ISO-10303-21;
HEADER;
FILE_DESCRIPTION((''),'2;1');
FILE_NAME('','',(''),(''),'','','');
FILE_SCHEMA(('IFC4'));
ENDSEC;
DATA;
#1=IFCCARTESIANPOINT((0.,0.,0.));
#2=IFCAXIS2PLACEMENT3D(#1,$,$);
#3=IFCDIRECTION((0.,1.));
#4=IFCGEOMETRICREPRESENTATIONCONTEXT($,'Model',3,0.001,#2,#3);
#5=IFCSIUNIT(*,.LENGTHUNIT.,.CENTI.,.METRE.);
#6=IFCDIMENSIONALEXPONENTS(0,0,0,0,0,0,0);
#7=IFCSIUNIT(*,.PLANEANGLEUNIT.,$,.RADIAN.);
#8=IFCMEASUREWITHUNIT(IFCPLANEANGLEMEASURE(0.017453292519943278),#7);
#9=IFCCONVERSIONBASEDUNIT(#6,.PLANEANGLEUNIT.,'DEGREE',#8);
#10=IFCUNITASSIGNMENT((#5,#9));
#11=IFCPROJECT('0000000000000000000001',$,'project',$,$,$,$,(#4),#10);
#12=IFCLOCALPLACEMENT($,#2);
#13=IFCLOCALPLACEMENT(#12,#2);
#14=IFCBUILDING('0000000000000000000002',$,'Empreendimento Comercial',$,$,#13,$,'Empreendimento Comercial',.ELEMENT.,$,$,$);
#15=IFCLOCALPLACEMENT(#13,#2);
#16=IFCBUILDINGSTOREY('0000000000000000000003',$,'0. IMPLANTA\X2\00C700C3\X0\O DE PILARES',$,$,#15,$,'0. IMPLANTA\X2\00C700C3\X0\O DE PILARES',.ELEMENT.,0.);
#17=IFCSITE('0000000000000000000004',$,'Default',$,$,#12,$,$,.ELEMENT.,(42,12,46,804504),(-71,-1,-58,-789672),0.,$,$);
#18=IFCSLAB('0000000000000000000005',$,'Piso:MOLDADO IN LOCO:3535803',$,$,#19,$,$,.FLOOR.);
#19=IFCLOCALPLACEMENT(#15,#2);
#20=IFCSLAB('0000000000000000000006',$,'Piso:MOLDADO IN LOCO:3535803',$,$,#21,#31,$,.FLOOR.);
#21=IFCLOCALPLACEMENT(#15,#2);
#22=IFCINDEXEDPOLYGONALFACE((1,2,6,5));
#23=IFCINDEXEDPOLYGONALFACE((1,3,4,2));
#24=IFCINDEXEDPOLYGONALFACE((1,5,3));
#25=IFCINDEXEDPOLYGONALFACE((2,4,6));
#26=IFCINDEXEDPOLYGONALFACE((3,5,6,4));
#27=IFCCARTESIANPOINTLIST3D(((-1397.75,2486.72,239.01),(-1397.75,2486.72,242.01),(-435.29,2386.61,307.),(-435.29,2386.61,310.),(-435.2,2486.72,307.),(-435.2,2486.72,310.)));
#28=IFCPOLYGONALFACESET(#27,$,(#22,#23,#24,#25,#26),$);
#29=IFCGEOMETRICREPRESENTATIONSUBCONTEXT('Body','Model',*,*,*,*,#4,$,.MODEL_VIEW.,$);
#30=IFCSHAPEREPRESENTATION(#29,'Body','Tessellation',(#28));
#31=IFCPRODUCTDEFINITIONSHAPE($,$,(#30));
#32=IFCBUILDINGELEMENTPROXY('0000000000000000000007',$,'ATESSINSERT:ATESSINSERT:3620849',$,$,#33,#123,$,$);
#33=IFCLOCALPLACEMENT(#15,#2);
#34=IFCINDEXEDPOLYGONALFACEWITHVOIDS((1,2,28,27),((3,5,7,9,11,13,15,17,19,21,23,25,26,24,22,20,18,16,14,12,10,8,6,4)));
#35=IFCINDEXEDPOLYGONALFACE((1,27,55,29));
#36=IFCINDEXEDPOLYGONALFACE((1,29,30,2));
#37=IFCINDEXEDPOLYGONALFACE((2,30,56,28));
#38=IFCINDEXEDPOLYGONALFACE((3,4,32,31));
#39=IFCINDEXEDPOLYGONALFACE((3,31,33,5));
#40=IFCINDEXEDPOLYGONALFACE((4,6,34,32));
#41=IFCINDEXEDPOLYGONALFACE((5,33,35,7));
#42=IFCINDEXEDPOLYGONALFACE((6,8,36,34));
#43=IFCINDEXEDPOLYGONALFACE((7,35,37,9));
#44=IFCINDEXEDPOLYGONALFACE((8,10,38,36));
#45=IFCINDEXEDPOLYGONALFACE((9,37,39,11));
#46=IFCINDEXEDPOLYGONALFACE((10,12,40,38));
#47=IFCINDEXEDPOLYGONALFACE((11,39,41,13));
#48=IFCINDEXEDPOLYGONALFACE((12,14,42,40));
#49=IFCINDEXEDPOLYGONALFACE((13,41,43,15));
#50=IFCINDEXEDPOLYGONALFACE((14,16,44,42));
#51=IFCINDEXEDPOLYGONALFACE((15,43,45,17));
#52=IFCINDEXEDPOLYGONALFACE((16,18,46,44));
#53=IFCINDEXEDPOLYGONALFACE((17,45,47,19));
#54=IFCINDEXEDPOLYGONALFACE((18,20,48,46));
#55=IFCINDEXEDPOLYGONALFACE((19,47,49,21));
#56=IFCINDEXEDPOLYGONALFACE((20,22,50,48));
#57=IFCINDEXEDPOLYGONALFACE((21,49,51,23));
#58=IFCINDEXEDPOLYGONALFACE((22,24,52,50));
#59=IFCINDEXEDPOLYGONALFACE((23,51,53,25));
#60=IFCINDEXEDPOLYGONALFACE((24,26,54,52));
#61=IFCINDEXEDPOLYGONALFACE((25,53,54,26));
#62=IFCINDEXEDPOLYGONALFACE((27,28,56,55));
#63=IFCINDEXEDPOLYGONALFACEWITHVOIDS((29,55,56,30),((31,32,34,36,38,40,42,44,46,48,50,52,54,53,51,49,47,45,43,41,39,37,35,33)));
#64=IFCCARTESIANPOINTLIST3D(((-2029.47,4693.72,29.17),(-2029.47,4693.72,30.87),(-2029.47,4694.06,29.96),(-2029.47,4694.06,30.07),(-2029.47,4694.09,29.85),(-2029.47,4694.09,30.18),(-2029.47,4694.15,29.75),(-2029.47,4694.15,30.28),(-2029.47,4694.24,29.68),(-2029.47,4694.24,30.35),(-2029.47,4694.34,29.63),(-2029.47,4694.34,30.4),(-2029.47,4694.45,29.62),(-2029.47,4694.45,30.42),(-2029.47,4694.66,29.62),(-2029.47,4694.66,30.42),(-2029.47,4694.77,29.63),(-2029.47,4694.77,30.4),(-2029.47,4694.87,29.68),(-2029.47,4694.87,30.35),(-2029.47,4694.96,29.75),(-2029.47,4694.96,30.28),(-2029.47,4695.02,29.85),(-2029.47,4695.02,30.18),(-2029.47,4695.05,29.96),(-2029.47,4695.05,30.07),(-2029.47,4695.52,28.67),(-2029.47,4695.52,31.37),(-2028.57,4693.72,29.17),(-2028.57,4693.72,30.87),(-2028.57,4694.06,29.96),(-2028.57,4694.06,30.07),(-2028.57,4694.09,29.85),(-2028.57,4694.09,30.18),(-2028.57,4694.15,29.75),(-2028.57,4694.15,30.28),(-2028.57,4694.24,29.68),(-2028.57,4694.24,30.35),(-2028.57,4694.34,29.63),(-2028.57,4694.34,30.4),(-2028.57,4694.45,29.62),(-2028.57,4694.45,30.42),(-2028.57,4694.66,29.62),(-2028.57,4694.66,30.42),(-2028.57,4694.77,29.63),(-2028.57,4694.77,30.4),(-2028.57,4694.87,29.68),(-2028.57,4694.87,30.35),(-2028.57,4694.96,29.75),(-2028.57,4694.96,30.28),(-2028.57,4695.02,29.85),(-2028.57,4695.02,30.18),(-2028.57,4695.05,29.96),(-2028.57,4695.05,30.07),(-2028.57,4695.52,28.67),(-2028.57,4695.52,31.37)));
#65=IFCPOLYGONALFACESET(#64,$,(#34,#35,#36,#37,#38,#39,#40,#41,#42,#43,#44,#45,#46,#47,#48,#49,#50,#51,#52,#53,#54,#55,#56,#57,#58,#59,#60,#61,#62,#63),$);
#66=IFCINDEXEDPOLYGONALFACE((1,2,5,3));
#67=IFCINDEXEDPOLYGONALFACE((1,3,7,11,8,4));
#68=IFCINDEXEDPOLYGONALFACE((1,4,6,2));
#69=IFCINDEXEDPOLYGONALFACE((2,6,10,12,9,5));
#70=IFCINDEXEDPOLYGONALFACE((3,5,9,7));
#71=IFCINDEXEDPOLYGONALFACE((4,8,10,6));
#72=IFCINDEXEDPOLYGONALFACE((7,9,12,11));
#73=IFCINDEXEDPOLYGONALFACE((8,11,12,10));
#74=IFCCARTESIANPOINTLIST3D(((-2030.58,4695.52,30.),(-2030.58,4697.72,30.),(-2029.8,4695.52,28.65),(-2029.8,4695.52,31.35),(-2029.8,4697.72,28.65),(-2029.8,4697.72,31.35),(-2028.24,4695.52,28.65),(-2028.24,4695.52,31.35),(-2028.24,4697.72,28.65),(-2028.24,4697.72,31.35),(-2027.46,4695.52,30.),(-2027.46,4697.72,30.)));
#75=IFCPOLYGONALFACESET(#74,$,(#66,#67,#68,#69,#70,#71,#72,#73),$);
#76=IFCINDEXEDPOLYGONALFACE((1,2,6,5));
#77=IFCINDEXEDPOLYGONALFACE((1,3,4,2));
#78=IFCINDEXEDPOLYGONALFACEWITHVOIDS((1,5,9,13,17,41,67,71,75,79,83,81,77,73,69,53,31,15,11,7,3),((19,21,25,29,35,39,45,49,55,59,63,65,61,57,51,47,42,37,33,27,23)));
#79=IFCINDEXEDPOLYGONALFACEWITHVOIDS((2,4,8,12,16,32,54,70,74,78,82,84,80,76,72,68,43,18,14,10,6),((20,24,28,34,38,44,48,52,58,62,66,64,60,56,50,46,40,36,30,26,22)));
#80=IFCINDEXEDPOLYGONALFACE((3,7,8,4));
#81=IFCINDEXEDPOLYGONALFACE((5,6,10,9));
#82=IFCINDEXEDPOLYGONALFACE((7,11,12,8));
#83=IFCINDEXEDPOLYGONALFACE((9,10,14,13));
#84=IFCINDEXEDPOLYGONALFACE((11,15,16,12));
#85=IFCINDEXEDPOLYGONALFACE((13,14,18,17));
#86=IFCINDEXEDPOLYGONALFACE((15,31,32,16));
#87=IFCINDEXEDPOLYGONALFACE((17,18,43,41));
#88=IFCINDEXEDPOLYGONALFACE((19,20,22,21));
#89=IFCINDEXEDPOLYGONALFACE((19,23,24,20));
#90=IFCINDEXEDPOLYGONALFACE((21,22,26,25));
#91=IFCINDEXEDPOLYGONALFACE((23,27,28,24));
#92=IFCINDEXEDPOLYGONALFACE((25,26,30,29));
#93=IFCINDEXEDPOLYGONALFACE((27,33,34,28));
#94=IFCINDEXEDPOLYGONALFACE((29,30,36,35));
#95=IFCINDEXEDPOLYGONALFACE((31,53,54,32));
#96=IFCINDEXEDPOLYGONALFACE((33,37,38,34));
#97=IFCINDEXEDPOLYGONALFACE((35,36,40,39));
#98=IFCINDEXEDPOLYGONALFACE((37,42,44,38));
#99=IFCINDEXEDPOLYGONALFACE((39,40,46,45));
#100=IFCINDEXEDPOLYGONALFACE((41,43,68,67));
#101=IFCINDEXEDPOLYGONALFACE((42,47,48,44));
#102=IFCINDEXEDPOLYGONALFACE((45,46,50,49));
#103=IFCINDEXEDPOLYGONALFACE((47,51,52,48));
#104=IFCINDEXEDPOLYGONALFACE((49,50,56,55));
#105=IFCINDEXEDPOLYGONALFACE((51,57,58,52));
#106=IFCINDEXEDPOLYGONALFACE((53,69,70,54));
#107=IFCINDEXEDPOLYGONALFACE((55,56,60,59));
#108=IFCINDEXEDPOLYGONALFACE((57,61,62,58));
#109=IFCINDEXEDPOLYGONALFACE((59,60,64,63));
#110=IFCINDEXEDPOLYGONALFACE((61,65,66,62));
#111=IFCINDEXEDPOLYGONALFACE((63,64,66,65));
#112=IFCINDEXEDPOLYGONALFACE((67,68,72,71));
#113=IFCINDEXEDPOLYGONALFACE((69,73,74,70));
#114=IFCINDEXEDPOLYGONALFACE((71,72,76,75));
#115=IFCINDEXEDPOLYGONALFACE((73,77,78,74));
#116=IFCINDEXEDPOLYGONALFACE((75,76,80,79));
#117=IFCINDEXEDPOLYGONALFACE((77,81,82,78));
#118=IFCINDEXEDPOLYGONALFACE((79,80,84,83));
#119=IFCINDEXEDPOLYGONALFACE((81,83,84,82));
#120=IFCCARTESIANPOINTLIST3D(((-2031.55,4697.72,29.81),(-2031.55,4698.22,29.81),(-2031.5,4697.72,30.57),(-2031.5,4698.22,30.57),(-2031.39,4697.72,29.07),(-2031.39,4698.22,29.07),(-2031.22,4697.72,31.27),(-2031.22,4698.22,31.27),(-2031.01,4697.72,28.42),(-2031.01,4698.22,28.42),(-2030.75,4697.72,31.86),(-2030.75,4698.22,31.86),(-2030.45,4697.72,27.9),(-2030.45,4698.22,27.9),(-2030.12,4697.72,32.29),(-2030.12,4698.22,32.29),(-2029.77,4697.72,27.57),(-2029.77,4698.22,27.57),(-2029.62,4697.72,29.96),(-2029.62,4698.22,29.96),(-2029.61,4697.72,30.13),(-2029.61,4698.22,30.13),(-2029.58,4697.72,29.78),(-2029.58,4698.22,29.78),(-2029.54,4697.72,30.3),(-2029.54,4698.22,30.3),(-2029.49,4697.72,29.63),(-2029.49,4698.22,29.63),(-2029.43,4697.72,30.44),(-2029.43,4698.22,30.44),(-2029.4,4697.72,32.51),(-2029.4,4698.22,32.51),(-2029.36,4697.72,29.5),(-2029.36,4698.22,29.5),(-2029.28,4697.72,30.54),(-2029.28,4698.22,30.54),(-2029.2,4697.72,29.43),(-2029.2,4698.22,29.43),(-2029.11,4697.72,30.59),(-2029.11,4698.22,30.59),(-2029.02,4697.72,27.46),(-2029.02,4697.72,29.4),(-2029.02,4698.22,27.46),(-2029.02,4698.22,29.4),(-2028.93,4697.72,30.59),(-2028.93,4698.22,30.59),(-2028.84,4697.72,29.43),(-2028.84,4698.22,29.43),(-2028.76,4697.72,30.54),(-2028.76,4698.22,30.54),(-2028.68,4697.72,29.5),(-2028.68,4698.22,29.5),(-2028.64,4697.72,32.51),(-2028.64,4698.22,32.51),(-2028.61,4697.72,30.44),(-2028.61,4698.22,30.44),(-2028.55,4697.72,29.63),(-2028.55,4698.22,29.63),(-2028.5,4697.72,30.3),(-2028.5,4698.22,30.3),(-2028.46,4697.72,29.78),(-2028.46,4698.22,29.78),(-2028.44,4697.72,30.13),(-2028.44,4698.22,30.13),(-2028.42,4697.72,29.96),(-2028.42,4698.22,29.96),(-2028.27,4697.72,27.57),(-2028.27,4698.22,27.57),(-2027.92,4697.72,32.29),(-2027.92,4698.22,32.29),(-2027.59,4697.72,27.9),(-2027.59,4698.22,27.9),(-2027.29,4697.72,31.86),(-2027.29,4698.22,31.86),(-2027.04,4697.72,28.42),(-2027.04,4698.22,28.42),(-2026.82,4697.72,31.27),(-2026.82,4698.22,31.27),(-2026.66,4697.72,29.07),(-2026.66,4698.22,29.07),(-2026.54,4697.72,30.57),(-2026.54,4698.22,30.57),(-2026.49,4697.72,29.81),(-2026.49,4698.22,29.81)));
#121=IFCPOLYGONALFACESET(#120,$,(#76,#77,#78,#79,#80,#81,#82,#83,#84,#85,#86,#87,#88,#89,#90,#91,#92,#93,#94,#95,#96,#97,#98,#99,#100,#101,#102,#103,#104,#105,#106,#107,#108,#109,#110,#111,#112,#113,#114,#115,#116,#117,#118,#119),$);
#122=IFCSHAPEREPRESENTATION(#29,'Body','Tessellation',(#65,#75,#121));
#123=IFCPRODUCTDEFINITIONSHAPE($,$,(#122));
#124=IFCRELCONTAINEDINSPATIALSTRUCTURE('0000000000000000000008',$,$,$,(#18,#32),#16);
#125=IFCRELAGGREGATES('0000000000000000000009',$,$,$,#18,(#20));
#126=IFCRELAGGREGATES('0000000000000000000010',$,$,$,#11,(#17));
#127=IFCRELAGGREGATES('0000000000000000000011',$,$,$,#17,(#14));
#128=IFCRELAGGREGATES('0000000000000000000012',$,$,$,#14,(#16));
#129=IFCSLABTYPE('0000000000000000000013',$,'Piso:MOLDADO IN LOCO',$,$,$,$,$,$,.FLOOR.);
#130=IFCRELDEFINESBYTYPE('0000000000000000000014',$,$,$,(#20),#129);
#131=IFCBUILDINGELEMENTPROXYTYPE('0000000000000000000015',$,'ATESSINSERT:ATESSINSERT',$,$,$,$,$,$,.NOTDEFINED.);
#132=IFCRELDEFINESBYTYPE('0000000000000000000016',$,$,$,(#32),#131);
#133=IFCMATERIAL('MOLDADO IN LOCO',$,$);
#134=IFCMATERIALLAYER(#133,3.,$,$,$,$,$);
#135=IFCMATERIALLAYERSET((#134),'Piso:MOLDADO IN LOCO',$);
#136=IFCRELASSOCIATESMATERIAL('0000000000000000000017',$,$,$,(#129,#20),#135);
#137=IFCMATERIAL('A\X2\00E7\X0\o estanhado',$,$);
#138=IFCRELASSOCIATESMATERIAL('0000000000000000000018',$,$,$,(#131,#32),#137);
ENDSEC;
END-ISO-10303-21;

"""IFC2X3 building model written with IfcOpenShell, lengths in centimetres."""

from ifc_helpers import new_model, entity, si_unit, converted_unit, direction, frame, frame_2d, origin, place, context, subcontext, project, spatial, polyline, circle_curve, parameter, trimmed, segment, composite_curve, hollow_circle, outline, extrude, source, transform, mapped, material, layer, layer_set, type_object, type_shapes, element, aggregate, save


model = new_model("IFC2X3")

# Units and contexts
model_context = context("Model", 3, precision=0.001, world=origin(), true_north=direction((0.0, 1.0)))
body_context = subcontext(model_context, "Body", "Model", "MODEL_VIEW")
ifc_project = project(units=[si_unit("LENGTHUNIT", "METRE", prefix="CENTI"), converted_unit("PLANEANGLEUNIT", "DEGREE", entity("IfcPlaneAngleMeasure", 0.017453292519943278), si_unit("PLANEANGLEUNIT", "RADIAN"), dimensions=[0, 0, 0, 0, 0, 0, 0])], contexts=[model_context])

# Site, building, storey
site_placement = place(None, origin())
site = spatial("IfcSite", under=ifc_project, at=site_placement, Name="Default", CompositionType="ELEMENT", RefLatitude=(42, 12, 46, 804504), RefLongitude=(-71, -1, -58, -789672), RefElevation=0.0)
building_placement = place(site_placement, origin())
building = spatial("IfcBuilding", under=site, at=building_placement, Name="Empreendimento Comercial", LongName="Empreendimento Comercial", CompositionType="ELEMENT")
storey_placement = place(building_placement, origin())
storey = spatial("IfcBuildingStorey", under=building, at=storey_placement, Name="0. IMPLANTAÇÃO DE PILARES", LongName="0. IMPLANTAÇÃO DE PILARES", CompositionType="ELEMENT", Elevation=0.0)

# Slabs
slab_1_placement = place(storey_placement, frame((-2049.02, 1986.72, 193.0)))
slab_1 = element("IfcSlab", 1, at=slab_1_placement, inside=storey, Name="Piso:MOLDADO IN LOCO:3535803", PredefinedType="FLOOR")
ifc_material_1 = material(Name="MOLDADO IN LOCO")
ifc_layer = layer(ifc_material_1, 3.0)
ifc_layer_set = layer_set([ifc_layer], Name="Piso:MOLDADO IN LOCO")
slab_type = type_object("IfcSlabType", Name="Piso:MOLDADO IN LOCO", PredefinedType="FLOOR", material=ifc_layer_set)
slab_2_placement = place(slab_1_placement, origin())
slab_2 = element("IfcSlab", 2, at=slab_2_placement, type_object=slab_type, material=ifc_layer_set, Name="Piso:MOLDADO IN LOCO:3535803", PredefinedType="FLOOR", context=body_context, shape_type="SweptSolid", body=[
    extrude(outline(polyline([(482.48, 50.06), (-482.48, 50.06), (482.38, -50.06), (482.48, 50.06)])), frame((1132.55, 449.94, 83.01), z_axis=(-0.070464, 0.000068, 0.997514), x_axis=(0.997514, 0.000005, 0.070464)), (-0.070464, 0.000068, -0.997514), 3.0),
])
aggregate(slab_1, [slab_2])

# Building element proxy
ifc_material_2 = material(Name="Aço estanhado")
building_element_proxy_type_1 = type_object("IfcBuildingElementProxyType", Name="ATESSINSERT:ATESSINSERT", PredefinedType="NOTDEFINED", material=ifc_material_2)
shared_shape_1 = source(origin(), body_context, "Body", "SweptSolid", [
    extrude(outline(polyline([(-1.35, -0.9), (1.35, -0.9), (0.85, 0.9), (-0.85, 0.9), (-1.35, -0.9)]), holes=[composite_curve([segment(trimmed(circle_curve(frame_2d((0.0, 0.17), x_axis=(1.0, 0.0)), 0.4), [parameter(0.0)], [parameter(180.0)], True, "PARAMETER"), False, "CONTINUOUS"), segment(polyline([(0.4, 0.17), (0.4, -0.03)]), True, "CONTINUOUS"), segment(trimmed(circle_curve(frame_2d((0.0, -0.03), x_axis=(1.0, 0.0)), 0.4), [parameter(180.0)], [parameter(0.0)], True, "PARAMETER"), False, "CONTINUOUS"), segment(polyline([(-0.4, -0.03), (-0.4, 0.17)]), True, "CONTINUOUS")], self_intersect=False)]), frame((-1.4, -0.45, 30.02), z_axis=(0.0, 1.0, 0.0), x_axis=(0.0, 0.0, 1.0)), (0.0, 0.0, 1.0), 0.9),
    extrude(outline(polyline([(-0.78, -1.35), (0.78, -1.35), (1.56, 0.0), (0.78, 1.35), (-0.78, 1.35), (-1.56, 0.0), (-0.78, -1.35)])), frame((-4.5, 0.0, 30.0), z_axis=(1.0, 0.0, 0.0), x_axis=(0.0, 0.5, 0.866025)), (0.0, 0.0, 1.0), 2.2),
    extrude(hollow_circle(Radius=2.54, WallThickness=1.94, at=frame_2d((0.0, 0.0), x_axis=(1.0, 0.0))), frame((-5.0, 0.0, 30.0), z_axis=(1.0, 0.0, 0.0), x_axis=(0.0, 0.0, -1.0)), (0.0, 0.0, 1.0), 0.5),
])
type_shapes(building_element_proxy_type_1, [shared_shape_1])
for number, where, z_axis, x_axis, name in (
    (3, (-2029.02, 4693.22, 0.0), (0.0, 0.0, 1.0), (0.0, -1.0, 0.0), "ATESSINSERT:ATESSINSERT:3620849"),
):
    element("IfcBuildingElementProxy", number, at=place(storey_placement, frame(where, z_axis=z_axis, x_axis=x_axis)), inside=storey, type_object=building_element_proxy_type_1, material=ifc_material_2, Name=name, context=body_context, shape_type="MappedRepresentation", body=[
        mapped(shared_shape_1, transform((0.0, 0.0, 0.0), scale=1.0)),
    ])

save(model, "model.ifc")
